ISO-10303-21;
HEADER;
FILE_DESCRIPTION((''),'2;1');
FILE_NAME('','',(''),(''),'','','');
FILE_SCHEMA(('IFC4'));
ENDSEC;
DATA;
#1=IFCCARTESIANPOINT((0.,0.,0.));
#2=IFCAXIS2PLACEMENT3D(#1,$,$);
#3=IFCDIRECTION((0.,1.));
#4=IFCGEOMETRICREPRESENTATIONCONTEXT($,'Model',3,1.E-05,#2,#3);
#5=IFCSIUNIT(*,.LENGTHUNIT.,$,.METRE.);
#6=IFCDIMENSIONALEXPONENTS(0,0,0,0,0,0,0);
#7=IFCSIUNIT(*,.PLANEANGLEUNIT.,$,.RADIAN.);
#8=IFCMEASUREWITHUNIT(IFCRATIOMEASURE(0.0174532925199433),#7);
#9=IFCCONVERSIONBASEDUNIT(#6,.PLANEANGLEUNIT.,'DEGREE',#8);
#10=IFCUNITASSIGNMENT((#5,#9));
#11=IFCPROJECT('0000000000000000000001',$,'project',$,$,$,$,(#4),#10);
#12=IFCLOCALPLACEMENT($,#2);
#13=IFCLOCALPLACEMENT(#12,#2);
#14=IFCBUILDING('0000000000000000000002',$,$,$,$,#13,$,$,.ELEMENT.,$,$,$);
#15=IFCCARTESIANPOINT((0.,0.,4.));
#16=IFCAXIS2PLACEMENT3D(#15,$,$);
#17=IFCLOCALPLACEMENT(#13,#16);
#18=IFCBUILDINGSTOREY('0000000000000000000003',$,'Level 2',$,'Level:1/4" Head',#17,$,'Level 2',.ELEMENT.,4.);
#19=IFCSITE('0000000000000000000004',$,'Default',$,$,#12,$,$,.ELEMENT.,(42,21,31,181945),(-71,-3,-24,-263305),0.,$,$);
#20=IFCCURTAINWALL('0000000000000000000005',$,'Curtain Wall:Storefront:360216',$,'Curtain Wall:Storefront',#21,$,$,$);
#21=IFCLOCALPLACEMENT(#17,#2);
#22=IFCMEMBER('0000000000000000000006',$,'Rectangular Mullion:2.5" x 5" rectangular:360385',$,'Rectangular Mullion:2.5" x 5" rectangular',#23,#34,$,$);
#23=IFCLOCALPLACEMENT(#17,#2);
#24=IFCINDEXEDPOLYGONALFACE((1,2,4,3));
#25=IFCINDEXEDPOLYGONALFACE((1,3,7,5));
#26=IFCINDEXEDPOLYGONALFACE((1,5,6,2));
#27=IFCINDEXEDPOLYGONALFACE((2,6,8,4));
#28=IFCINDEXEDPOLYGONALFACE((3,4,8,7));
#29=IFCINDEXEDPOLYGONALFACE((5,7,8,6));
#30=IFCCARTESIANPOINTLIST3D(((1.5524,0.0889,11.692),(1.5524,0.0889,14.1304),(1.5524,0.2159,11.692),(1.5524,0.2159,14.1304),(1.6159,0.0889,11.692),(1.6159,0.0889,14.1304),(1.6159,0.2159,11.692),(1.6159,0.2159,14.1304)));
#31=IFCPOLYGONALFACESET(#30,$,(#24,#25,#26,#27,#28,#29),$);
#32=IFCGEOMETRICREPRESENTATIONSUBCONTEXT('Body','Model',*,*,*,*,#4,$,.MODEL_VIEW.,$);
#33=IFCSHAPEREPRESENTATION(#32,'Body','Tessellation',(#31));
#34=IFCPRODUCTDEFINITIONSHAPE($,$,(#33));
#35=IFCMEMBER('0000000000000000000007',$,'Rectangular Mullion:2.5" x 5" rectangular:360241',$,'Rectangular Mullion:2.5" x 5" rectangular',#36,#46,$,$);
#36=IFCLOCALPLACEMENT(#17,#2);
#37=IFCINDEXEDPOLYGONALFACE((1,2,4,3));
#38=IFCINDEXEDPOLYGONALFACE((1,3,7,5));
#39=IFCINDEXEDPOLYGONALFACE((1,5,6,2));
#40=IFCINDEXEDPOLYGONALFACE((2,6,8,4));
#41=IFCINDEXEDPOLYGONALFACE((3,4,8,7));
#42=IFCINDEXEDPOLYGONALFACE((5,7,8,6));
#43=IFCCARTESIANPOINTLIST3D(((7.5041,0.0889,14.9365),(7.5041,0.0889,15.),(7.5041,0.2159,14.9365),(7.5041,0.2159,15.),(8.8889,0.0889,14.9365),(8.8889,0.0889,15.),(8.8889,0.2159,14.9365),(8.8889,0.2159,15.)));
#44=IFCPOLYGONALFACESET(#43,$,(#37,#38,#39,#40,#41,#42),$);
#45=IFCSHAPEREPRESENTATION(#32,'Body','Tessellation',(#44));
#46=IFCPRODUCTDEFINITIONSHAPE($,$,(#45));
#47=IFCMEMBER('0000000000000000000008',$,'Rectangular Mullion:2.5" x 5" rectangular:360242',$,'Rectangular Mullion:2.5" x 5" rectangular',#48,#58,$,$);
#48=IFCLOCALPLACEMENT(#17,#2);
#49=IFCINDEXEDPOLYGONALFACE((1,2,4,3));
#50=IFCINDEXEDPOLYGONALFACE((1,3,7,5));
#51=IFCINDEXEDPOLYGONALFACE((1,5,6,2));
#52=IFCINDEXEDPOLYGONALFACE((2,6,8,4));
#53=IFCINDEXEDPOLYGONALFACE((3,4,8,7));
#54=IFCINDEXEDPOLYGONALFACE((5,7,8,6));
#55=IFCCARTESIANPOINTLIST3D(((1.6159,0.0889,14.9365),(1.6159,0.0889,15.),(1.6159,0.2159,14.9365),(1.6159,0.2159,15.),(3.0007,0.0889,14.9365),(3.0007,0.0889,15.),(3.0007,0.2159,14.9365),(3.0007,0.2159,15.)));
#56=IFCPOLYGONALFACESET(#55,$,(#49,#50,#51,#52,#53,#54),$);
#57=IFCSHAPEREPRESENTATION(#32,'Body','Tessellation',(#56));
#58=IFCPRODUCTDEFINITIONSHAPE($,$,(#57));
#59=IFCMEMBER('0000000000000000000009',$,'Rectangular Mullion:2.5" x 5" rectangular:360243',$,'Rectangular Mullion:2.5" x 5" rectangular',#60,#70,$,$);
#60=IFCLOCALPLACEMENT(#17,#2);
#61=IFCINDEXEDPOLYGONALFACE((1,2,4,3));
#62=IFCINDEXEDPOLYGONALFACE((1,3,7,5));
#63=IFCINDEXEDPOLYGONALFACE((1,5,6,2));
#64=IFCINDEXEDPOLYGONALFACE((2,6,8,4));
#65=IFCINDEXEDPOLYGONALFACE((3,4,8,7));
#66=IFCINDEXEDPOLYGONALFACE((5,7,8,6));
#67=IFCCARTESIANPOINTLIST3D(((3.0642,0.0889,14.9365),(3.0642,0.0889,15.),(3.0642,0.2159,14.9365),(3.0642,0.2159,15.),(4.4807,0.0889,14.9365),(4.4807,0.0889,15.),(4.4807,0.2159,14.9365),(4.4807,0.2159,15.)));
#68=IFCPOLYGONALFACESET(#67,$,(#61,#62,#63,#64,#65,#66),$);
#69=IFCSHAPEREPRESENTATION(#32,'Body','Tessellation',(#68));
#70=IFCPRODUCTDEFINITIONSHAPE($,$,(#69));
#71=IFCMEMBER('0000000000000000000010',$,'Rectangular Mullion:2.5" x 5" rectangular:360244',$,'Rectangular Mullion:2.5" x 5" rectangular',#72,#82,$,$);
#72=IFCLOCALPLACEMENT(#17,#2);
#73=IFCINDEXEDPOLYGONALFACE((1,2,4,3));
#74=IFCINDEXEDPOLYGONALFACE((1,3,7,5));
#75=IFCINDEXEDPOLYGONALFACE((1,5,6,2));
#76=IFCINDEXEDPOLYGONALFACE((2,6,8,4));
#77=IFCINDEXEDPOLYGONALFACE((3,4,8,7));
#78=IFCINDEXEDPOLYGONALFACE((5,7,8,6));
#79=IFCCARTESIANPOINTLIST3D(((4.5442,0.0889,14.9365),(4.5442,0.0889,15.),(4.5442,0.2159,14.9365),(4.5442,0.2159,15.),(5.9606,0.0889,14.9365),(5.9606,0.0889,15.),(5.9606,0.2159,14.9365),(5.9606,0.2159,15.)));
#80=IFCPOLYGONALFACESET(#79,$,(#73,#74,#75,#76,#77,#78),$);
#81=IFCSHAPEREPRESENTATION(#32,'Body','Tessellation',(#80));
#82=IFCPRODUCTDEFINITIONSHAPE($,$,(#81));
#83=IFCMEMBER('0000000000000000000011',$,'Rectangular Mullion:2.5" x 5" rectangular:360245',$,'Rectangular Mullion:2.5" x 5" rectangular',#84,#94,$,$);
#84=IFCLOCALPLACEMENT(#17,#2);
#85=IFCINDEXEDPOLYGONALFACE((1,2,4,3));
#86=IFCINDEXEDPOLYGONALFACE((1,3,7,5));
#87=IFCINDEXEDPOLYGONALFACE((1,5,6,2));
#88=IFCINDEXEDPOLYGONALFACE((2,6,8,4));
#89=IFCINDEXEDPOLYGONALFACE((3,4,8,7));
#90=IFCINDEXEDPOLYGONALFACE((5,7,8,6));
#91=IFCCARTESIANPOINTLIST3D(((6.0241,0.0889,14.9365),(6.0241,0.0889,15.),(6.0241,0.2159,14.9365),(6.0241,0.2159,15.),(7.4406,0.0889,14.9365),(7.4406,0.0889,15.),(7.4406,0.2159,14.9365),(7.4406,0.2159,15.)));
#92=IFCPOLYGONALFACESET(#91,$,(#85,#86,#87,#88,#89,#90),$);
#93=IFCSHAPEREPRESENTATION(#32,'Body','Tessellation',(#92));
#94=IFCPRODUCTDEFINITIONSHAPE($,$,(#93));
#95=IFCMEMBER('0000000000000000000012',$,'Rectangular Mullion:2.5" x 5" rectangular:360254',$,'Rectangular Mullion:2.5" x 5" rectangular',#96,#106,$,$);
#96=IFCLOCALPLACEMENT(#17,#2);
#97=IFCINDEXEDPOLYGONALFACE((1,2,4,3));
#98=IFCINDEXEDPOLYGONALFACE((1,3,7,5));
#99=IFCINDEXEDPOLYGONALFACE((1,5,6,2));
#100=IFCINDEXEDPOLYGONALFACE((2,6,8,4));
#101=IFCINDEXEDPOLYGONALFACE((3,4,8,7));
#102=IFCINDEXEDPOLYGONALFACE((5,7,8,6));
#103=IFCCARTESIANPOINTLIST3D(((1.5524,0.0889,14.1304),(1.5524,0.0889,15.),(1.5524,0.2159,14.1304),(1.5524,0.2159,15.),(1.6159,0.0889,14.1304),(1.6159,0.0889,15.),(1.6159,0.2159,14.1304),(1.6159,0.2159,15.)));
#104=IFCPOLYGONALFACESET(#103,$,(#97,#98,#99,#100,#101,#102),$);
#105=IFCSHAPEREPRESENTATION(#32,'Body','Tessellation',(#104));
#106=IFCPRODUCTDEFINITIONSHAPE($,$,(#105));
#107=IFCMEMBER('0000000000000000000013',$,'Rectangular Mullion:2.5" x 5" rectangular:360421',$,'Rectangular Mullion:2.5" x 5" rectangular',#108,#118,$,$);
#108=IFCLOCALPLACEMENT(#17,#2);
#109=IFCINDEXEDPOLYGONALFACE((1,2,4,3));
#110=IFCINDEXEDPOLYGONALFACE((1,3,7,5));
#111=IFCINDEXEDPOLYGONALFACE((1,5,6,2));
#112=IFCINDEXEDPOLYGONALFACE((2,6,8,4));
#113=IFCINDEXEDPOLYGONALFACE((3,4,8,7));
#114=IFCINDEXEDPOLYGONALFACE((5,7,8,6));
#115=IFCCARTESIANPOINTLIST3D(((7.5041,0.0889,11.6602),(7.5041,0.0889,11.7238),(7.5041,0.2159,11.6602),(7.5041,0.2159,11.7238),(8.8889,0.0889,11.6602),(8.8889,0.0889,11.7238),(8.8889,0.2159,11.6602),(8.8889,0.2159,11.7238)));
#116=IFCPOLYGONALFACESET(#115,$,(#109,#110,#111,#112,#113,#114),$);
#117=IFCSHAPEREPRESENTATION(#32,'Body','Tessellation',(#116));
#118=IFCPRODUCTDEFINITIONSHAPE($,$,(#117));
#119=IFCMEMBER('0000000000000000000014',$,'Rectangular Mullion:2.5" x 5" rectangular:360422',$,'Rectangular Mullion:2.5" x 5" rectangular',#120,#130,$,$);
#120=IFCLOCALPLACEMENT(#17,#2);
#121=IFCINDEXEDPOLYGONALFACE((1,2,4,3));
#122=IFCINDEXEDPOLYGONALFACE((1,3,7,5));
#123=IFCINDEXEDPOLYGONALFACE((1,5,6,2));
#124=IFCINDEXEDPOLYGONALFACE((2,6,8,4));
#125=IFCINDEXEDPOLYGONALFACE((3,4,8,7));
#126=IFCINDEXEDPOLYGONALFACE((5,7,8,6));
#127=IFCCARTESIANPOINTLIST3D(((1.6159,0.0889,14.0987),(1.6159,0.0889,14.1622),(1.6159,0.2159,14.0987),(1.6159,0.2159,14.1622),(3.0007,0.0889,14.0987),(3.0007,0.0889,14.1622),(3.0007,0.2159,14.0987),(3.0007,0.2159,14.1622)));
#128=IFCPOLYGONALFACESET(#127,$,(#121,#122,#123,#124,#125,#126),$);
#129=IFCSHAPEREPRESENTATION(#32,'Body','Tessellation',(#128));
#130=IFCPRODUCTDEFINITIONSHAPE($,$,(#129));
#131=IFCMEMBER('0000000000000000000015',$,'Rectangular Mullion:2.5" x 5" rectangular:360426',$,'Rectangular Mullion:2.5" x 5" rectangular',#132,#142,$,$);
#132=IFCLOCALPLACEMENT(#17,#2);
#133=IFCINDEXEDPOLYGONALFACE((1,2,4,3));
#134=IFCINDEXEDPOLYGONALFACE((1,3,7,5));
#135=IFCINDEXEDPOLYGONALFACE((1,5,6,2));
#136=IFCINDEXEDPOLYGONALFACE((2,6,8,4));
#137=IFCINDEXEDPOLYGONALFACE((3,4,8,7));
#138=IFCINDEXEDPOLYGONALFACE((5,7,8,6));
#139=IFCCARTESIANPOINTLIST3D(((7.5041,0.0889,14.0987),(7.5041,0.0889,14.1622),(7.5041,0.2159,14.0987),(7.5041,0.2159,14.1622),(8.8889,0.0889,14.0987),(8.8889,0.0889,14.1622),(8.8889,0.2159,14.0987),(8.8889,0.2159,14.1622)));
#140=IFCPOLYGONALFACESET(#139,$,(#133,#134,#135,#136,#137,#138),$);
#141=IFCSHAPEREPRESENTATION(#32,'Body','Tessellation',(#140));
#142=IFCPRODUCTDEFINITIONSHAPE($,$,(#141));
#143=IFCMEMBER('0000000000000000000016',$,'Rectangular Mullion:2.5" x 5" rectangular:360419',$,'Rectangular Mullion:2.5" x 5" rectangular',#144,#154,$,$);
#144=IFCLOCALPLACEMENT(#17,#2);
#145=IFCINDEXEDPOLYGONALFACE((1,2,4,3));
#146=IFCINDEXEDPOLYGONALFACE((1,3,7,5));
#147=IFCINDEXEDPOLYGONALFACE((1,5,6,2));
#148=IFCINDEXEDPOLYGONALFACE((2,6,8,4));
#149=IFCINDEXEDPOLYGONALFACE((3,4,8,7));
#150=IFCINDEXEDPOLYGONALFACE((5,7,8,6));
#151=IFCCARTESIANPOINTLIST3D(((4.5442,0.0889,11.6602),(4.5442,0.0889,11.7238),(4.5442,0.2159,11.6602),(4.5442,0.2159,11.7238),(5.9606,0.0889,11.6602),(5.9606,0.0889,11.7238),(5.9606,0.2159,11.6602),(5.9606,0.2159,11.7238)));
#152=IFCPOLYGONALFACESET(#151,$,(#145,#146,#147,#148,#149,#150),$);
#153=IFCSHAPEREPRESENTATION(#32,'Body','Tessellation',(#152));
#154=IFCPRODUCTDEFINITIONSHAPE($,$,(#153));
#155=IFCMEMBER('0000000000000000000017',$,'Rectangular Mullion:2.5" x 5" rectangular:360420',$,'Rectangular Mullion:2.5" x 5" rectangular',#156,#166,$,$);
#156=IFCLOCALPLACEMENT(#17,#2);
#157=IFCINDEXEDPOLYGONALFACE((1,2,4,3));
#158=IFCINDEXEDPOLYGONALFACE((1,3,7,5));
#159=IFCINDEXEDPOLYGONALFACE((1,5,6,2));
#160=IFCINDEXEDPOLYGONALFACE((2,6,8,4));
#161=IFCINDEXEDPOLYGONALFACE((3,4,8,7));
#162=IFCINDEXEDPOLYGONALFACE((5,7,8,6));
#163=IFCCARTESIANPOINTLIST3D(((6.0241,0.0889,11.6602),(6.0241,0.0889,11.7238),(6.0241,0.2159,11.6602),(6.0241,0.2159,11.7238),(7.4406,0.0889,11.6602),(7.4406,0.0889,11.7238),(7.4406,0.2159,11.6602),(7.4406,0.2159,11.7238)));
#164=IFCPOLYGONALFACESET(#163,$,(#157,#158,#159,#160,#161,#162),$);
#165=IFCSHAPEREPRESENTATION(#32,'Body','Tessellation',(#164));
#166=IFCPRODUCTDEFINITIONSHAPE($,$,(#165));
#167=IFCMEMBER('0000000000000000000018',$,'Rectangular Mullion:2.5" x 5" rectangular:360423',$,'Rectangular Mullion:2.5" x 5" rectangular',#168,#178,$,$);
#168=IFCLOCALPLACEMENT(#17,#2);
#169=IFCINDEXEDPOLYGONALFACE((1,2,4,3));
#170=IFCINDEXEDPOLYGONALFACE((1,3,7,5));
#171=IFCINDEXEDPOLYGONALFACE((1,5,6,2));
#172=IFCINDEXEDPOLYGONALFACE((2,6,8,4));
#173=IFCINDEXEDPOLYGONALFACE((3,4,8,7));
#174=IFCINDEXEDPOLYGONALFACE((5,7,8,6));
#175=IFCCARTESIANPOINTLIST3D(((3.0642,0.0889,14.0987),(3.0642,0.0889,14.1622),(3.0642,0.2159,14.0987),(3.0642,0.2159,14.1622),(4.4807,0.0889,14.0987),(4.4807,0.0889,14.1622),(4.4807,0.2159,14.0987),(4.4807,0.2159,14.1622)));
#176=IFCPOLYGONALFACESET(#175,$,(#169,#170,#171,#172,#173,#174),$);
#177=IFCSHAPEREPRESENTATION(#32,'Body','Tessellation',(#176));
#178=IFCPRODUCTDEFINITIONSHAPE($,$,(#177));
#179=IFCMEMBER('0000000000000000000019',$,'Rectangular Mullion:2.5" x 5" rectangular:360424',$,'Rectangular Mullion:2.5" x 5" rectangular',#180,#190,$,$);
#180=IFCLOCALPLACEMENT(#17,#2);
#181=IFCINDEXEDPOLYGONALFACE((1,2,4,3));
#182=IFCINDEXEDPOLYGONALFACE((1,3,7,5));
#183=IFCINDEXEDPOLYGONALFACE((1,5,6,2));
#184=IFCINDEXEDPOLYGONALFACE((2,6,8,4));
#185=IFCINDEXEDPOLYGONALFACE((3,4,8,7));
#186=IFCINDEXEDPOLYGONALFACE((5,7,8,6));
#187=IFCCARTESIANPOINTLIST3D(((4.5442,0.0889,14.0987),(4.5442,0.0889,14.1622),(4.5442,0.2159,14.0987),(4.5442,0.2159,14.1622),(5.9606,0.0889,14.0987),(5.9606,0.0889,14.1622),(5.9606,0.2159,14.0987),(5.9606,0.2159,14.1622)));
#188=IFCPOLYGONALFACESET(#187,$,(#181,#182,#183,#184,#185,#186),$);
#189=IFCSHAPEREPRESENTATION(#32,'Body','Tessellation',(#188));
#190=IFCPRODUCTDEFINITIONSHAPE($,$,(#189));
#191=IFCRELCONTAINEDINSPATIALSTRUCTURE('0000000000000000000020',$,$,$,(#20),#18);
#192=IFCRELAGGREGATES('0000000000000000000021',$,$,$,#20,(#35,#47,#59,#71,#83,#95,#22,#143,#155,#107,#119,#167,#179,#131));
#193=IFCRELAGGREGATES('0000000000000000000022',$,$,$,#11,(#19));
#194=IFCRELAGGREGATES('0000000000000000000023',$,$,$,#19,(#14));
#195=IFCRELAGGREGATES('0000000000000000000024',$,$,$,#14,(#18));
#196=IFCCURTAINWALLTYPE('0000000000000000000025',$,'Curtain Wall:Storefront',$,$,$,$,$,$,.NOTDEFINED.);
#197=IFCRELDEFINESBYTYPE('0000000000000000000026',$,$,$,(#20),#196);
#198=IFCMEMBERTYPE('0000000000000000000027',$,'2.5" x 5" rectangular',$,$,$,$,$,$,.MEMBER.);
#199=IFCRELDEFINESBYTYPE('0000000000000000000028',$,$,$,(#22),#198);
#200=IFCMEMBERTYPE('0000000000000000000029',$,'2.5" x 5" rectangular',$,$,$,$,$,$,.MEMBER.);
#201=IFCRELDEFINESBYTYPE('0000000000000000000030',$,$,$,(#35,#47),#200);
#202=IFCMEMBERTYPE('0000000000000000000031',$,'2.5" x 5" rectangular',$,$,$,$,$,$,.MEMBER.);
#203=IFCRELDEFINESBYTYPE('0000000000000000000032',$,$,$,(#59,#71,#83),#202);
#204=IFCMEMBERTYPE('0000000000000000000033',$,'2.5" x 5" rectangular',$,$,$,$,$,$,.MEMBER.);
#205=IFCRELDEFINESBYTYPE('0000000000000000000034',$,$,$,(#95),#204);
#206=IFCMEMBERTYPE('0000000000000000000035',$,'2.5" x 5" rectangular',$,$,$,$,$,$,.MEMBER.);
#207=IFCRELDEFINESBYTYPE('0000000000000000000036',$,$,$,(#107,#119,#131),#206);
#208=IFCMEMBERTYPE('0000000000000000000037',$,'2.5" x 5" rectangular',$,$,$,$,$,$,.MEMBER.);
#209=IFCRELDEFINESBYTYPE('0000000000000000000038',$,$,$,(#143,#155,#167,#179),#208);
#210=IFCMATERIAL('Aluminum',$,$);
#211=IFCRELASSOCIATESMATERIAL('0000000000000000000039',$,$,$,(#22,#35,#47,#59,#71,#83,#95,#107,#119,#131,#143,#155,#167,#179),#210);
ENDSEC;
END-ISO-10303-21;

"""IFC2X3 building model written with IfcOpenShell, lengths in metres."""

from ifc_helpers import new_model, entity, si_unit, converted_unit, direction, frame, origin, origin_2d_with_axis, place, context, subcontext, project, spatial, rectangle, extrude, source, transform, mapped, material, type_object, type_shapes, element, aggregate, save


model = new_model("IFC2X3")

# Units and contexts
model_context = context("Model", 3, precision=1e-05, world=origin(), true_north=direction((0.0, 1.0)))
body_context = subcontext(model_context, "Body", "Model", "MODEL_VIEW")
ifc_project = project(units=[si_unit("LENGTHUNIT", "METRE"), converted_unit("PLANEANGLEUNIT", "DEGREE", entity("IfcRatioMeasure", 0.0174532925199433), si_unit("PLANEANGLEUNIT", "RADIAN"), dimensions=[0, 0, 0, 0, 0, 0, 0])], contexts=[model_context])

# Site, building, storey
site_placement = place(None, origin())
site = spatial("IfcSite", under=ifc_project, at=site_placement, Name="Default", CompositionType="ELEMENT", RefLatitude=(42, 21, 31, 181945), RefLongitude=(-71, -3, -24, -263305), RefElevation=0.0)
building_placement = place(site_placement, origin())
building = spatial("IfcBuilding", under=site, at=building_placement, CompositionType="ELEMENT")
storey_placement = place(building_placement, frame((0.0, 0.0, 4.0)))
storey = spatial("IfcBuildingStorey", under=building, at=storey_placement, Name="Level 2", ObjectType="Level:1/4\" Head", LongName="Level 2", CompositionType="ELEMENT", Elevation=4.0)

# Curtain wall, members
curtain_wall_type = type_object("IfcCurtainWallType", Name="Curtain Wall:Storefront", PredefinedType="NOTDEFINED")
curtain_wall_placement = place(storey_placement, frame((0.0, 0.0, -4.0)))
curtain_wall = element("IfcCurtainWall", 1, at=curtain_wall_placement, inside=storey, type_object=curtain_wall_type, Name="Curtain Wall:Storefront:360216", ObjectType="Curtain Wall:Storefront")
ifc_material_1 = material(Name="Aluminum")
member_type_1 = type_object("IfcMemberType", Name="2.5\" x 5\" rectangular", PredefinedType="MEMBER")
shared_shape_1 = source(origin(), body_context, "Body", "SweptSolid", [
    extrude(rectangle(XDim=0.127, YDim=0.0635, at=origin_2d_with_axis()), frame((-0.0318, 0.0, -2.4384), z_axis=(0.0, 0.0, 1.0), x_axis=(0.0, -1.0, 0.0)), (0.0, 0.0, 1.0), 2.4384),
])
type_shapes(member_type_1, [shared_shape_1])
member_1_placement = place(storey_placement, frame((1.5524, 0.1524, 14.1304), z_axis=(0.0, 0.0, 1.0), x_axis=(-1.0, 0.0, 0.0)))
member_1 = element("IfcMember", 2, at=member_1_placement, type_object=member_type_1, material=ifc_material_1, Name="Rectangular Mullion:2.5\" x 5\" rectangular:360385", ObjectType="Rectangular Mullion:2.5\" x 5\" rectangular", context=body_context, shape_type="MappedRepresentation", body=[
    mapped(shared_shape_1, transform((0.0, 0.0, 0.0), scale=1.0)),
])
member_type_2 = type_object("IfcMemberType", Name="2.5\" x 5\" rectangular", PredefinedType="MEMBER")
shared_shape_2 = source(origin(), body_context, "Body", "SweptSolid", [
    extrude(rectangle(XDim=0.127, YDim=0.0635, at=origin_2d_with_axis()), frame((-0.0318, 0.0, -1.3848), z_axis=(0.0, 0.0, 1.0), x_axis=(0.0, -1.0, 0.0)), (0.0, 0.0, 1.0), 1.3848),
])
type_shapes(member_type_2, [shared_shape_2])
member_2_placement = place(storey_placement, frame((8.8889, 0.1524, 15.0), z_axis=(1.0, 0.0, 0.0), x_axis=(0.0, 0.0, 1.0)))
member_2 = element("IfcMember", 3, at=member_2_placement, type_object=member_type_2, material=ifc_material_1, Name="Rectangular Mullion:2.5\" x 5\" rectangular:360241", ObjectType="Rectangular Mullion:2.5\" x 5\" rectangular", context=body_context, shape_type="MappedRepresentation", body=[
    mapped(shared_shape_2, transform((0.0, 0.0, 0.0), scale=1.0)),
])
member_3_placement = place(storey_placement, frame((3.0007, 0.1524, 15.0), z_axis=(1.0, 0.0, 0.0), x_axis=(0.0, 0.0, 1.0)))
member_3 = element("IfcMember", 4, at=member_3_placement, type_object=member_type_2, material=ifc_material_1, Name="Rectangular Mullion:2.5\" x 5\" rectangular:360242", ObjectType="Rectangular Mullion:2.5\" x 5\" rectangular", context=body_context, shape_type="MappedRepresentation", body=[
    mapped(shared_shape_2, transform((0.0, 0.0, 0.0), scale=1.0)),
])
member_type_3 = type_object("IfcMemberType", Name="2.5\" x 5\" rectangular", PredefinedType="MEMBER")
shared_shape_3 = source(origin(), body_context, "Body", "SweptSolid", [
    extrude(rectangle(XDim=0.127, YDim=0.0635, at=origin_2d_with_axis()), frame((-0.0318, 0.0, -1.4165), z_axis=(0.0, 0.0, 1.0), x_axis=(0.0, -1.0, 0.0)), (0.0, 0.0, 1.0), 1.4165),
])
type_shapes(member_type_3, [shared_shape_3])
member_4_placement = place(storey_placement, frame((4.4807, 0.1524, 15.0), z_axis=(1.0, 0.0, 0.0), x_axis=(0.0, 0.0, 1.0)))
member_4 = element("IfcMember", 5, at=member_4_placement, type_object=member_type_3, material=ifc_material_1, Name="Rectangular Mullion:2.5\" x 5\" rectangular:360243", ObjectType="Rectangular Mullion:2.5\" x 5\" rectangular", context=body_context, shape_type="MappedRepresentation", body=[
    mapped(shared_shape_3, transform((0.0, 0.0, 0.0), scale=1.0)),
])
member_5_placement = place(storey_placement, frame((5.9606, 0.1524, 15.0), z_axis=(1.0, 0.0, 0.0), x_axis=(0.0, 0.0, 1.0)))
member_5 = element("IfcMember", 6, at=member_5_placement, type_object=member_type_3, material=ifc_material_1, Name="Rectangular Mullion:2.5\" x 5\" rectangular:360244", ObjectType="Rectangular Mullion:2.5\" x 5\" rectangular", context=body_context, shape_type="MappedRepresentation", body=[
    mapped(shared_shape_3, transform((0.0, 0.0, 0.0), scale=1.0)),
])
member_6_placement = place(storey_placement, frame((7.4406, 0.1524, 15.0), z_axis=(1.0, 0.0, 0.0), x_axis=(0.0, 0.0, 1.0)))
member_6 = element("IfcMember", 7, at=member_6_placement, type_object=member_type_3, material=ifc_material_1, Name="Rectangular Mullion:2.5\" x 5\" rectangular:360245", ObjectType="Rectangular Mullion:2.5\" x 5\" rectangular", context=body_context, shape_type="MappedRepresentation", body=[
    mapped(shared_shape_3, transform((0.0, 0.0, 0.0), scale=1.0)),
])
member_type_4 = type_object("IfcMemberType", Name="2.5\" x 5\" rectangular", PredefinedType="MEMBER")
shared_shape_4 = source(origin(), body_context, "Body", "SweptSolid", [
    extrude(rectangle(XDim=0.127, YDim=0.0635, at=origin_2d_with_axis()), frame((-0.0318, 0.0, -0.8696), z_axis=(0.0, 0.0, 1.0), x_axis=(0.0, -1.0, 0.0)), (0.0, 0.0, 1.0), 0.8696),
])
type_shapes(member_type_4, [shared_shape_4])
member_7_placement = place(storey_placement, frame((1.5524, 0.1524, 15.0), z_axis=(0.0, 0.0, 1.0), x_axis=(-1.0, 0.0, 0.0)))
member_7 = element("IfcMember", 8, at=member_7_placement, type_object=member_type_4, material=ifc_material_1, Name="Rectangular Mullion:2.5\" x 5\" rectangular:360254", ObjectType="Rectangular Mullion:2.5\" x 5\" rectangular", context=body_context, shape_type="MappedRepresentation", body=[
    mapped(shared_shape_4, transform((0.0, 0.0, 0.0), scale=1.0)),
])
member_type_5 = type_object("IfcMemberType", Name="2.5\" x 5\" rectangular", PredefinedType="MEMBER")
shared_shape_5 = source(origin(), body_context, "Body", "SweptSolid", [
    extrude(rectangle(XDim=0.127, YDim=0.0635, at=origin_2d_with_axis()), frame((0.0, 0.0, -1.3848), z_axis=(0.0, 0.0, 1.0), x_axis=(0.0, -1.0, 0.0)), (0.0, 0.0, 1.0), 1.3848),
])
type_shapes(member_type_5, [shared_shape_5])
member_8_placement = place(storey_placement, frame((8.8889, 0.1524, 11.692), z_axis=(1.0, 0.0, 0.0), x_axis=(0.0, 0.0, 1.0)))
member_8 = element("IfcMember", 9, at=member_8_placement, type_object=member_type_5, material=ifc_material_1, Name="Rectangular Mullion:2.5\" x 5\" rectangular:360421", ObjectType="Rectangular Mullion:2.5\" x 5\" rectangular", context=body_context, shape_type="MappedRepresentation", body=[
    mapped(shared_shape_5, transform((0.0, 0.0, 0.0), scale=1.0)),
])
member_9_placement = place(storey_placement, frame((3.0007, 0.1524, 14.1304), z_axis=(1.0, 0.0, 0.0), x_axis=(0.0, 0.0, 1.0)))
member_9 = element("IfcMember", 10, at=member_9_placement, type_object=member_type_5, material=ifc_material_1, Name="Rectangular Mullion:2.5\" x 5\" rectangular:360422", ObjectType="Rectangular Mullion:2.5\" x 5\" rectangular", context=body_context, shape_type="MappedRepresentation", body=[
    mapped(shared_shape_5, transform((0.0, 0.0, 0.0), scale=1.0)),
])
member_10_placement = place(storey_placement, frame((8.8889, 0.1524, 14.1304), z_axis=(1.0, 0.0, 0.0), x_axis=(0.0, 0.0, 1.0)))
member_10 = element("IfcMember", 11, at=member_10_placement, type_object=member_type_5, material=ifc_material_1, Name="Rectangular Mullion:2.5\" x 5\" rectangular:360426", ObjectType="Rectangular Mullion:2.5\" x 5\" rectangular", context=body_context, shape_type="MappedRepresentation", body=[
    mapped(shared_shape_5, transform((0.0, 0.0, 0.0), scale=1.0)),
])
member_type_6 = type_object("IfcMemberType", Name="2.5\" x 5\" rectangular", PredefinedType="MEMBER")
shared_shape_6 = source(origin(), body_context, "Body", "SweptSolid", [
    extrude(rectangle(XDim=0.127, YDim=0.0635, at=origin_2d_with_axis()), frame((0.0, 0.0, -1.4165), z_axis=(0.0, 0.0, 1.0), x_axis=(0.0, -1.0, 0.0)), (0.0, 0.0, 1.0), 1.4165),
])
type_shapes(member_type_6, [shared_shape_6])
member_11_placement = place(storey_placement, frame((5.9606, 0.1524, 11.692), z_axis=(1.0, 0.0, 0.0), x_axis=(0.0, 0.0, 1.0)))
member_11 = element("IfcMember", 12, at=member_11_placement, type_object=member_type_6, material=ifc_material_1, Name="Rectangular Mullion:2.5\" x 5\" rectangular:360419", ObjectType="Rectangular Mullion:2.5\" x 5\" rectangular", context=body_context, shape_type="MappedRepresentation", body=[
    mapped(shared_shape_6, transform((0.0, 0.0, 0.0), scale=1.0)),
])
member_12_placement = place(storey_placement, frame((7.4406, 0.1524, 11.692), z_axis=(1.0, 0.0, 0.0), x_axis=(0.0, 0.0, 1.0)))
member_12 = element("IfcMember", 13, at=member_12_placement, type_object=member_type_6, material=ifc_material_1, Name="Rectangular Mullion:2.5\" x 5\" rectangular:360420", ObjectType="Rectangular Mullion:2.5\" x 5\" rectangular", context=body_context, shape_type="MappedRepresentation", body=[
    mapped(shared_shape_6, transform((0.0, 0.0, 0.0), scale=1.0)),
])
member_13_placement = place(storey_placement, frame((4.4807, 0.1524, 14.1304), z_axis=(1.0, 0.0, 0.0), x_axis=(0.0, 0.0, 1.0)))
member_13 = element("IfcMember", 14, at=member_13_placement, type_object=member_type_6, material=ifc_material_1, Name="Rectangular Mullion:2.5\" x 5\" rectangular:360423", ObjectType="Rectangular Mullion:2.5\" x 5\" rectangular", context=body_context, shape_type="MappedRepresentation", body=[
    mapped(shared_shape_6, transform((0.0, 0.0, 0.0), scale=1.0)),
])
member_14_placement = place(storey_placement, frame((5.9606, 0.1524, 14.1304), z_axis=(1.0, 0.0, 0.0), x_axis=(0.0, 0.0, 1.0)))
member_14 = element("IfcMember", 15, at=member_14_placement, type_object=member_type_6, material=ifc_material_1, Name="Rectangular Mullion:2.5\" x 5\" rectangular:360424", ObjectType="Rectangular Mullion:2.5\" x 5\" rectangular", context=body_context, shape_type="MappedRepresentation", body=[
    mapped(shared_shape_6, transform((0.0, 0.0, 0.0), scale=1.0)),
])
aggregate(curtain_wall, [member_2, member_3, member_4, member_5, member_6, member_7, member_1, member_11, member_12, member_8, member_9, member_13, member_14, member_10])

save(model, "model.ifc")
